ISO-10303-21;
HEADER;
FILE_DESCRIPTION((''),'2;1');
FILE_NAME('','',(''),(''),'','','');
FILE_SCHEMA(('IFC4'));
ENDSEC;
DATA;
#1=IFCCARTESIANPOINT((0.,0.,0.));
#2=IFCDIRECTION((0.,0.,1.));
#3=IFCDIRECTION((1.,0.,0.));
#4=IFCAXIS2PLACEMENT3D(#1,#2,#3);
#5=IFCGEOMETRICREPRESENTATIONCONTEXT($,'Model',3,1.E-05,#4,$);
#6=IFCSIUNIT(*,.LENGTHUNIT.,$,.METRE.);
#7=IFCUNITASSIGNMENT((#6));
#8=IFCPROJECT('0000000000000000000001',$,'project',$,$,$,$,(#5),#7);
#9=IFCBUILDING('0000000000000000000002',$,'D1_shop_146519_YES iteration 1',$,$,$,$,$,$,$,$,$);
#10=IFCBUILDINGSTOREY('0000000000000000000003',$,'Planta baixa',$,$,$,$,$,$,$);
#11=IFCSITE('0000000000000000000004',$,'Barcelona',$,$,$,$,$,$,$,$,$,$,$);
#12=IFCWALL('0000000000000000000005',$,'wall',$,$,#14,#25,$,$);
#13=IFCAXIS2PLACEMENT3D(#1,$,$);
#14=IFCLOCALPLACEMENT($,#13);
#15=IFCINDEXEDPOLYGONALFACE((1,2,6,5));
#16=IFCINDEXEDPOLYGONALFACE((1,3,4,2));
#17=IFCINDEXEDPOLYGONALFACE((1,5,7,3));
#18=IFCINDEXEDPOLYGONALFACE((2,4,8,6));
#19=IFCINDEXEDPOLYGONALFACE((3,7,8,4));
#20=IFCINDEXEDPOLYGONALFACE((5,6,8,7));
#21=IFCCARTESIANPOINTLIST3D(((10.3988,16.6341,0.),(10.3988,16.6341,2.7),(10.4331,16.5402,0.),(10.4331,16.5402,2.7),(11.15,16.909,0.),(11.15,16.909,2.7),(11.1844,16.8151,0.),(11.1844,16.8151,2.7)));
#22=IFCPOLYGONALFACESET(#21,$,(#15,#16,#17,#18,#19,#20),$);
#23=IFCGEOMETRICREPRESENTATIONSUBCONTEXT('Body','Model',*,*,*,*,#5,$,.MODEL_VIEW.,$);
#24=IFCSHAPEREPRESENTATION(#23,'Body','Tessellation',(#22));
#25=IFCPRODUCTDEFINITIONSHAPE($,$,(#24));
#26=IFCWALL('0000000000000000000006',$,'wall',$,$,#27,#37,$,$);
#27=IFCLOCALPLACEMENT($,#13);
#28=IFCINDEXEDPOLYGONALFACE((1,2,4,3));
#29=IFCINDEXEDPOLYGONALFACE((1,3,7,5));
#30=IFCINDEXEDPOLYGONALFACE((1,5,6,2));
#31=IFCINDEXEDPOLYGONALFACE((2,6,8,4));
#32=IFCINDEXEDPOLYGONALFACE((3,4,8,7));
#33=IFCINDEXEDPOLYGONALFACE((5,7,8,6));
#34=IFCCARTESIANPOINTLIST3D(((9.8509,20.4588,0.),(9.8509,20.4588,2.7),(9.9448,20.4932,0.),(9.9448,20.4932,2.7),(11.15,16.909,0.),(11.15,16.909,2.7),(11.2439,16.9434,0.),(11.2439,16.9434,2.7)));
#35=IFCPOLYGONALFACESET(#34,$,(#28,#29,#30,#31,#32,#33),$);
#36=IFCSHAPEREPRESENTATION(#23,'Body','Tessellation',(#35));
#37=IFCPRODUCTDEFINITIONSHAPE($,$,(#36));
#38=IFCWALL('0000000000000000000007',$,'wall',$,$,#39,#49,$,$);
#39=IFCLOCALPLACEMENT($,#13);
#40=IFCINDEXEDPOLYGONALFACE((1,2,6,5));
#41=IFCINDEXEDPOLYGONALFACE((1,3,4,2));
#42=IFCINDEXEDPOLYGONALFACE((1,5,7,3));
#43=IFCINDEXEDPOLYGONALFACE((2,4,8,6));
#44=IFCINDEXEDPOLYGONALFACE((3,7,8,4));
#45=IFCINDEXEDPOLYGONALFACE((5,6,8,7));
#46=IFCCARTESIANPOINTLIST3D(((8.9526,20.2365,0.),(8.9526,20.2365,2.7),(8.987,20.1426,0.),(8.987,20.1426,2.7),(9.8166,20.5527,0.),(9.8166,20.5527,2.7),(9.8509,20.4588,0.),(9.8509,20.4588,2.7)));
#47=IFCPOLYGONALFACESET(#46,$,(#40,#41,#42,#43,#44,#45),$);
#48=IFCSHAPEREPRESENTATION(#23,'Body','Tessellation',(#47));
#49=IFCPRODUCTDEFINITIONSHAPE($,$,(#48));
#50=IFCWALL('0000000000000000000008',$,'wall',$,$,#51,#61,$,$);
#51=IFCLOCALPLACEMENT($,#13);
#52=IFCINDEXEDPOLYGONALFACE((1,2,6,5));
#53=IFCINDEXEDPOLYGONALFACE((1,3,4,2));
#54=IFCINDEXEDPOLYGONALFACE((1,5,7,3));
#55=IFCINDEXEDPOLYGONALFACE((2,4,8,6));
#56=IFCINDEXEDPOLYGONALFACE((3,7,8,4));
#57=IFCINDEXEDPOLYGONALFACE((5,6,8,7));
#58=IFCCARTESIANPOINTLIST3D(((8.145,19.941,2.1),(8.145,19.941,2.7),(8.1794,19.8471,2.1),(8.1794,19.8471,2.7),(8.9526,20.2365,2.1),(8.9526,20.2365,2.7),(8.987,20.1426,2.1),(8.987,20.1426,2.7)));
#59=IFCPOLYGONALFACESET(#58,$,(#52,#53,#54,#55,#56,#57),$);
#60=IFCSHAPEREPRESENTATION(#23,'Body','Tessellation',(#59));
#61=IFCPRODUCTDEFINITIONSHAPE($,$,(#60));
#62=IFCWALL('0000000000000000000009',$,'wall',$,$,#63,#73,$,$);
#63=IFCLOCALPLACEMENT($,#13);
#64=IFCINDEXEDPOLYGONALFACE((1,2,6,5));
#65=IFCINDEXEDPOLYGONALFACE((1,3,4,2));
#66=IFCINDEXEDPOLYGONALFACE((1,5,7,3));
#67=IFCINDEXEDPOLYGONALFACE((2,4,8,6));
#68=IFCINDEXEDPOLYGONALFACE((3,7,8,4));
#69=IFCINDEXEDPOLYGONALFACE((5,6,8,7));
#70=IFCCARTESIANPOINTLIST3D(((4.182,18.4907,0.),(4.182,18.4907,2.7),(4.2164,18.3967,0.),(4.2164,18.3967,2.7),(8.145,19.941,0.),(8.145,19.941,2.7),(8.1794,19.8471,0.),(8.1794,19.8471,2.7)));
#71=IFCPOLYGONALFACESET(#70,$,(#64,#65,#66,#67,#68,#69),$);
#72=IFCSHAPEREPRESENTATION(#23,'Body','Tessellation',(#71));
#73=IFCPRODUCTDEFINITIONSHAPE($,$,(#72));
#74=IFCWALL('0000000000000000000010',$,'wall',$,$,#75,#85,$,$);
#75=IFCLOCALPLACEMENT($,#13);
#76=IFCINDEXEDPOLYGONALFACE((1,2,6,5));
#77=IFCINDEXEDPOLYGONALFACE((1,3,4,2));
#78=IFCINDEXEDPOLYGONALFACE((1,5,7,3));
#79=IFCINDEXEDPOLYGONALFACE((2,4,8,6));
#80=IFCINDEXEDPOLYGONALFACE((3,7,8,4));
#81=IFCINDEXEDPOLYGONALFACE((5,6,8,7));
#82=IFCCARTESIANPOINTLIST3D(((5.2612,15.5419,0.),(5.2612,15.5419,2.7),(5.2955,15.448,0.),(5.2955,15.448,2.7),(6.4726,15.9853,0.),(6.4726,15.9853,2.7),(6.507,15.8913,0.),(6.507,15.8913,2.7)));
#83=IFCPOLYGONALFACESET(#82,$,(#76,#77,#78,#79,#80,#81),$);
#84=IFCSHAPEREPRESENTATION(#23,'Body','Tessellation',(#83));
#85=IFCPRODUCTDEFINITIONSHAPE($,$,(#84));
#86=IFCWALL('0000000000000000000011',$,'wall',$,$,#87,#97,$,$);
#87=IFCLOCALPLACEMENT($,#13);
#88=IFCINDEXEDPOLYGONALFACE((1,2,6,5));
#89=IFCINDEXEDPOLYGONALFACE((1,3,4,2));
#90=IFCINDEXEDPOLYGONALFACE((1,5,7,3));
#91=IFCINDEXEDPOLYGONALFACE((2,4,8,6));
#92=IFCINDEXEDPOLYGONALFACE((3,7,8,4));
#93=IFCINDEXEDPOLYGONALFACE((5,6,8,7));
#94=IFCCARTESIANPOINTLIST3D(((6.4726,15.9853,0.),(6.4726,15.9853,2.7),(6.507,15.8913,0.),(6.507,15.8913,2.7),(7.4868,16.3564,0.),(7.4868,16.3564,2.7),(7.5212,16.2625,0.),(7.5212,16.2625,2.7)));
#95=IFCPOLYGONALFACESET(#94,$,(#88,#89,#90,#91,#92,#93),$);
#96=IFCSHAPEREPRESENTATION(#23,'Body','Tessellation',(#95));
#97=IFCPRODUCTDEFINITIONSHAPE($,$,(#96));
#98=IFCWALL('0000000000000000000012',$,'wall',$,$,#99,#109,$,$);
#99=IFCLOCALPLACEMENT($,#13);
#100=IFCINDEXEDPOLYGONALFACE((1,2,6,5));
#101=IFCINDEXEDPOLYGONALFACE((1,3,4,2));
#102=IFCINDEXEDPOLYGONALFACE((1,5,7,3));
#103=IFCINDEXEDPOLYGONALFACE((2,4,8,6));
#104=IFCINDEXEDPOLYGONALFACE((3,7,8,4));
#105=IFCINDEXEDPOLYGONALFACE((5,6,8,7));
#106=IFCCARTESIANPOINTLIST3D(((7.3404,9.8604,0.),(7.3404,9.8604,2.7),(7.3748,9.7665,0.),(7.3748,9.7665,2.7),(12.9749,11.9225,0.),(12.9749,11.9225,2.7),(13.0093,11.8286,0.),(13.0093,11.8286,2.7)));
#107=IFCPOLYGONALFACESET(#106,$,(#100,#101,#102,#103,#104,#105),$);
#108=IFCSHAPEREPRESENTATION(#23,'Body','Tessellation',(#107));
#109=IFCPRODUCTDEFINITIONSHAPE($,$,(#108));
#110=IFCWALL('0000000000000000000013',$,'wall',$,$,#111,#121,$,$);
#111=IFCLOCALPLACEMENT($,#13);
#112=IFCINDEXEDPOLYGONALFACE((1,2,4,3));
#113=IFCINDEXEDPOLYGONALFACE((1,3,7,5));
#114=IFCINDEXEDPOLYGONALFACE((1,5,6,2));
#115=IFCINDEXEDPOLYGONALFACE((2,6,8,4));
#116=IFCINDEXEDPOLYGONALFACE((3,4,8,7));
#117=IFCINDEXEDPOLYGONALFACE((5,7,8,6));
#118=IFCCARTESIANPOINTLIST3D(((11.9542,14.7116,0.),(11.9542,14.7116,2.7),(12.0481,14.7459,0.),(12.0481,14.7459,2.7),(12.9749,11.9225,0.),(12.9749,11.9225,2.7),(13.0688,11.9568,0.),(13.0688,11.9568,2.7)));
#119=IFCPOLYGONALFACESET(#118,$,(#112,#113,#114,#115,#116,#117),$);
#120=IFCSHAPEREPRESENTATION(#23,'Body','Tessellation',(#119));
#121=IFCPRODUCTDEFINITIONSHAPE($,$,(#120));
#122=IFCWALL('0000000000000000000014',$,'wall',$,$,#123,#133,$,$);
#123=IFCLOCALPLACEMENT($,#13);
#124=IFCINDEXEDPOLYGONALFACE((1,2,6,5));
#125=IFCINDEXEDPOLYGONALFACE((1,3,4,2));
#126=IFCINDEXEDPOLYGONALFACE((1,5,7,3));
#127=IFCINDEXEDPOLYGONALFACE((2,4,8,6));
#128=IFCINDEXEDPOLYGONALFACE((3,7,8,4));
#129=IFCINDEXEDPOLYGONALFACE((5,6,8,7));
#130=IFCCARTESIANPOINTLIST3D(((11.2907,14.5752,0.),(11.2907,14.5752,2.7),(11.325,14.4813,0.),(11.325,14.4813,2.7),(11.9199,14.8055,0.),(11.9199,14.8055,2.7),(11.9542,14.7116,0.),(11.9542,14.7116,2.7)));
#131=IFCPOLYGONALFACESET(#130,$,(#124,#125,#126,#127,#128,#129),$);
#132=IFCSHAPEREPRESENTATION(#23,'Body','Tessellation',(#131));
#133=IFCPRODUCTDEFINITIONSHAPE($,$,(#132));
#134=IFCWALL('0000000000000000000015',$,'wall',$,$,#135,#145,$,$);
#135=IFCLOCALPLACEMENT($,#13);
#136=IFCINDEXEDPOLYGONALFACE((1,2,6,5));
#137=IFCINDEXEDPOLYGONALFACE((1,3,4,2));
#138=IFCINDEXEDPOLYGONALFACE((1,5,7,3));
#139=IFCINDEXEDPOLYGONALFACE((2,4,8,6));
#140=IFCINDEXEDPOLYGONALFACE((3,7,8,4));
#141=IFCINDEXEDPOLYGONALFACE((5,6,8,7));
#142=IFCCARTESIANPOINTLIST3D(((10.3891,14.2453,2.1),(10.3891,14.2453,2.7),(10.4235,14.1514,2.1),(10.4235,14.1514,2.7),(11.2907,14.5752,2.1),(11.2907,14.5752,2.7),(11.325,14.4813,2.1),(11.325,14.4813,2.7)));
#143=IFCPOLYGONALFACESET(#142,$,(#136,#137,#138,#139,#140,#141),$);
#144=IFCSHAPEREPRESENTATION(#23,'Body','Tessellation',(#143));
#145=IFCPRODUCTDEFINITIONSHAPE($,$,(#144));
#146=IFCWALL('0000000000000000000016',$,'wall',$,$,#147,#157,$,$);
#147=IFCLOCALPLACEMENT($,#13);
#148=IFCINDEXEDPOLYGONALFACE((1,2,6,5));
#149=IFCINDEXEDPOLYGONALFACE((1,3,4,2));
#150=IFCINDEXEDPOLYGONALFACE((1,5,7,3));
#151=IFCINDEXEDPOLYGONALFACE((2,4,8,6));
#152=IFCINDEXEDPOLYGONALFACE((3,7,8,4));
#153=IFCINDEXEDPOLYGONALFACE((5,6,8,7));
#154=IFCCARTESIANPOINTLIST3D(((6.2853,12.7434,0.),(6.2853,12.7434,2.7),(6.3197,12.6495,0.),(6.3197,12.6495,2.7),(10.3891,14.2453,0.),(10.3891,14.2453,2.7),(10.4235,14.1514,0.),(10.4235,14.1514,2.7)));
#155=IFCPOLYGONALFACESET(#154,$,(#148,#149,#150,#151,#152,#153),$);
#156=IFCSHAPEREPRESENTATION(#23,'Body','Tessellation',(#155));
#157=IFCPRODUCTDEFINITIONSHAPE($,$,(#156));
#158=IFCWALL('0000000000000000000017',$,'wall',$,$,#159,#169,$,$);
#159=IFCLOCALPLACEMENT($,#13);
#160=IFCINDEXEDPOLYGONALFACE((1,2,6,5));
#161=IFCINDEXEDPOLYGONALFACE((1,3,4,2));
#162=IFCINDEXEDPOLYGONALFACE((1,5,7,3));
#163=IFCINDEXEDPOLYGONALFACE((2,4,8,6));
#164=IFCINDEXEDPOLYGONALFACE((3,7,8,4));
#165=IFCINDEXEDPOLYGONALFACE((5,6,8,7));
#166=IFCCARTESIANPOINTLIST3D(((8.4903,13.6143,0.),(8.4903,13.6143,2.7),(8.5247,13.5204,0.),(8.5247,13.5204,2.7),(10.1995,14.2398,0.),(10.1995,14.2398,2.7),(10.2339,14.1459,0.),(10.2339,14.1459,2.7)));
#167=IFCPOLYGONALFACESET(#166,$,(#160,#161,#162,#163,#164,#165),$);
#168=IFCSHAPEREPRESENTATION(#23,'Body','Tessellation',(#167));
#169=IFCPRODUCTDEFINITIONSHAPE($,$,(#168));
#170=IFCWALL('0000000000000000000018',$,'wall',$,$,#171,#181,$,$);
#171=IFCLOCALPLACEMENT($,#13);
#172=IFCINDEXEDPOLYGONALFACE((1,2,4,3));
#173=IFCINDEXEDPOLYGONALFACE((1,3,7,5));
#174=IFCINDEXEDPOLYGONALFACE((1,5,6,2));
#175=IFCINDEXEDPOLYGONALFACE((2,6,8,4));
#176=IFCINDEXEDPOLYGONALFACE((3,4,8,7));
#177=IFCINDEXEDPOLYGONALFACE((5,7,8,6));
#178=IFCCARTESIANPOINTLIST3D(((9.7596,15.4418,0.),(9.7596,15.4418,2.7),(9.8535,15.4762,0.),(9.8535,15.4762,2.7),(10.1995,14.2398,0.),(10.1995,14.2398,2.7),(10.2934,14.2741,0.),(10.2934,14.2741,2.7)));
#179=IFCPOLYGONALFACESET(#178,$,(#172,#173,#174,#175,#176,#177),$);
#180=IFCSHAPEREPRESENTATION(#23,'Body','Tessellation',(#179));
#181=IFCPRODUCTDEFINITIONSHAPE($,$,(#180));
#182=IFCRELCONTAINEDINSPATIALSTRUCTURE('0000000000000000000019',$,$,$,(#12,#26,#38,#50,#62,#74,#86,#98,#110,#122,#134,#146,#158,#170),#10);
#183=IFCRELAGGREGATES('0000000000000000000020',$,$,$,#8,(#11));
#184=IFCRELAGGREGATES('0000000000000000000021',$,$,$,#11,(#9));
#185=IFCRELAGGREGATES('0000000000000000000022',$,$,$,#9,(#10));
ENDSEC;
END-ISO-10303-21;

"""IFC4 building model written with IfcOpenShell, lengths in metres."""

from ifc_helpers import new_model, si_unit, frame, origin, origin_with_axes, place, context, subcontext, project, spatial, polyline, outline, extrude, element, save


model = new_model("IFC4")

# Units and contexts
model_context = context("Model", 3, precision=1e-05, world=origin_with_axes())
body_context = subcontext(model_context, "Body", "Model", "MODEL_VIEW")
ifc_project = project(units=[si_unit("LENGTHUNIT", "METRE")], contexts=[model_context])

# Site, building, storey
site = spatial("IfcSite", under=ifc_project, Name="Barcelona")
building = spatial("IfcBuilding", under=site, Name="D1_shop_146519_YES iteration 1")
storey = spatial("IfcBuildingStorey", under=building, Name="Planta baixa")

# Walls
wall_1_placement = place(None, origin_with_axes())
element("IfcWall", 1, at=wall_1_placement, inside=storey, Name="wall", context=body_context, shape_type="SweptSolid", body=[
    extrude(outline(polyline([(10.3988, 16.6341), (11.15, 16.909), (11.1844, 16.8151), (10.4331, 16.5402), (10.3988, 16.6341)])), origin(), (0.0, 0.0, 1.0), 2.7),
])
wall_2_placement = place(None, origin_with_axes())
element("IfcWall", 2, at=wall_2_placement, inside=storey, Name="wall", context=body_context, shape_type="SweptSolid", body=[
    extrude(outline(polyline([(11.15, 16.909), (9.8509, 20.4588), (9.9448, 20.4932), (11.2439, 16.9434), (11.15, 16.909)])), origin(), (0.0, 0.0, 1.0), 2.7),
])
wall_3_placement = place(None, origin_with_axes())
element("IfcWall", 3, at=wall_3_placement, inside=storey, Name="wall", context=body_context, shape_type="SweptSolid", body=[
    extrude(outline(polyline([(9.8509, 20.4588), (8.987, 20.1426), (8.9526, 20.2365), (9.8166, 20.5527), (9.8509, 20.4588)])), origin(), (0.0, 0.0, 1.0), 2.7),
])
wall_4_placement = place(None, origin_with_axes())
element("IfcWall", 4, at=wall_4_placement, inside=storey, Name="wall", context=body_context, shape_type="SweptSolid", body=[
    extrude(outline(polyline([(8.987, 20.1426), (8.1794, 19.8471), (8.145, 19.941), (8.9526, 20.2365), (8.987, 20.1426)])), frame((0.0, 0.0, 2.1)), (0.0, 0.0, 1.0), 0.6),
])
wall_5_placement = place(None, origin_with_axes())
element("IfcWall", 5, at=wall_5_placement, inside=storey, Name="wall", context=body_context, shape_type="SweptSolid", body=[
    extrude(outline(polyline([(8.1794, 19.8471), (4.2164, 18.3967), (4.182, 18.4907), (8.145, 19.941), (8.1794, 19.8471)])), origin(), (0.0, 0.0, 1.0), 2.7),
])
wall_6_placement = place(None, origin_with_axes())
element("IfcWall", 6, at=wall_6_placement, inside=storey, Name="wall", context=body_context, shape_type="SweptSolid", body=[
    extrude(outline(polyline([(5.2612, 15.5419), (6.4726, 15.9853), (6.507, 15.8913), (5.2955, 15.448), (5.2612, 15.5419)])), origin(), (0.0, 0.0, 1.0), 2.7),
])
wall_7_placement = place(None, origin_with_axes())
element("IfcWall", 7, at=wall_7_placement, inside=storey, Name="wall", context=body_context, shape_type="SweptSolid", body=[
    extrude(outline(polyline([(6.4726, 15.9853), (7.4868, 16.3564), (7.5212, 16.2625), (6.507, 15.8913), (6.4726, 15.9853)])), origin(), (0.0, 0.0, 1.0), 2.7),
])
wall_8_placement = place(None, origin_with_axes())
element("IfcWall", 8, at=wall_8_placement, inside=storey, Name="wall", context=body_context, shape_type="SweptSolid", body=[
    extrude(outline(polyline([(7.3404, 9.8604), (12.9749, 11.9225), (13.0093, 11.8286), (7.3748, 9.7665), (7.3404, 9.8604)])), origin(), (0.0, 0.0, 1.0), 2.7),
])
wall_9_placement = place(None, origin_with_axes())
element("IfcWall", 9, at=wall_9_placement, inside=storey, Name="wall", context=body_context, shape_type="SweptSolid", body=[
    extrude(outline(polyline([(12.9749, 11.9225), (11.9542, 14.7116), (12.0481, 14.7459), (13.0688, 11.9568), (12.9749, 11.9225)])), origin(), (0.0, 0.0, 1.0), 2.7),
])
wall_10_placement = place(None, origin_with_axes())
element("IfcWall", 10, at=wall_10_placement, inside=storey, Name="wall", context=body_context, shape_type="SweptSolid", body=[
    extrude(outline(polyline([(11.9542, 14.7116), (11.325, 14.4813), (11.2907, 14.5752), (11.9199, 14.8055), (11.9542, 14.7116)])), origin(), (0.0, 0.0, 1.0), 2.7),
])
wall_11_placement = place(None, origin_with_axes())
element("IfcWall", 11, at=wall_11_placement, inside=storey, Name="wall", context=body_context, shape_type="SweptSolid", body=[
    extrude(outline(polyline([(11.325, 14.4813), (10.4235, 14.1514), (10.3891, 14.2453), (11.2907, 14.5752), (11.325, 14.4813)])), frame((0.0, 0.0, 2.1)), (0.0, 0.0, 1.0), 0.6),
])
wall_12_placement = place(None, origin_with_axes())
element("IfcWall", 12, at=wall_12_placement, inside=storey, Name="wall", context=body_context, shape_type="SweptSolid", body=[
    extrude(outline(polyline([(10.4235, 14.1514), (6.3197, 12.6495), (6.2853, 12.7434), (10.3891, 14.2453), (10.4235, 14.1514)])), origin(), (0.0, 0.0, 1.0), 2.7),
])
wall_13_placement = place(None, origin_with_axes())
element("IfcWall", 13, at=wall_13_placement, inside=storey, Name="wall", context=body_context, shape_type="SweptSolid", body=[
    extrude(outline(polyline([(8.4903, 13.6143), (10.1995, 14.2398), (10.2339, 14.1459), (8.5247, 13.5204), (8.4903, 13.6143)])), origin(), (0.0, 0.0, 1.0), 2.7),
])
wall_14_placement = place(None, origin_with_axes())
element("IfcWall", 14, at=wall_14_placement, inside=storey, Name="wall", context=body_context, shape_type="SweptSolid", body=[
    extrude(outline(polyline([(10.1995, 14.2398), (9.7596, 15.4418), (9.8535, 15.4762), (10.2934, 14.2741), (10.1995, 14.2398)])), origin(), (0.0, 0.0, 1.0), 2.7),
])

save(model, "model.ifc")
